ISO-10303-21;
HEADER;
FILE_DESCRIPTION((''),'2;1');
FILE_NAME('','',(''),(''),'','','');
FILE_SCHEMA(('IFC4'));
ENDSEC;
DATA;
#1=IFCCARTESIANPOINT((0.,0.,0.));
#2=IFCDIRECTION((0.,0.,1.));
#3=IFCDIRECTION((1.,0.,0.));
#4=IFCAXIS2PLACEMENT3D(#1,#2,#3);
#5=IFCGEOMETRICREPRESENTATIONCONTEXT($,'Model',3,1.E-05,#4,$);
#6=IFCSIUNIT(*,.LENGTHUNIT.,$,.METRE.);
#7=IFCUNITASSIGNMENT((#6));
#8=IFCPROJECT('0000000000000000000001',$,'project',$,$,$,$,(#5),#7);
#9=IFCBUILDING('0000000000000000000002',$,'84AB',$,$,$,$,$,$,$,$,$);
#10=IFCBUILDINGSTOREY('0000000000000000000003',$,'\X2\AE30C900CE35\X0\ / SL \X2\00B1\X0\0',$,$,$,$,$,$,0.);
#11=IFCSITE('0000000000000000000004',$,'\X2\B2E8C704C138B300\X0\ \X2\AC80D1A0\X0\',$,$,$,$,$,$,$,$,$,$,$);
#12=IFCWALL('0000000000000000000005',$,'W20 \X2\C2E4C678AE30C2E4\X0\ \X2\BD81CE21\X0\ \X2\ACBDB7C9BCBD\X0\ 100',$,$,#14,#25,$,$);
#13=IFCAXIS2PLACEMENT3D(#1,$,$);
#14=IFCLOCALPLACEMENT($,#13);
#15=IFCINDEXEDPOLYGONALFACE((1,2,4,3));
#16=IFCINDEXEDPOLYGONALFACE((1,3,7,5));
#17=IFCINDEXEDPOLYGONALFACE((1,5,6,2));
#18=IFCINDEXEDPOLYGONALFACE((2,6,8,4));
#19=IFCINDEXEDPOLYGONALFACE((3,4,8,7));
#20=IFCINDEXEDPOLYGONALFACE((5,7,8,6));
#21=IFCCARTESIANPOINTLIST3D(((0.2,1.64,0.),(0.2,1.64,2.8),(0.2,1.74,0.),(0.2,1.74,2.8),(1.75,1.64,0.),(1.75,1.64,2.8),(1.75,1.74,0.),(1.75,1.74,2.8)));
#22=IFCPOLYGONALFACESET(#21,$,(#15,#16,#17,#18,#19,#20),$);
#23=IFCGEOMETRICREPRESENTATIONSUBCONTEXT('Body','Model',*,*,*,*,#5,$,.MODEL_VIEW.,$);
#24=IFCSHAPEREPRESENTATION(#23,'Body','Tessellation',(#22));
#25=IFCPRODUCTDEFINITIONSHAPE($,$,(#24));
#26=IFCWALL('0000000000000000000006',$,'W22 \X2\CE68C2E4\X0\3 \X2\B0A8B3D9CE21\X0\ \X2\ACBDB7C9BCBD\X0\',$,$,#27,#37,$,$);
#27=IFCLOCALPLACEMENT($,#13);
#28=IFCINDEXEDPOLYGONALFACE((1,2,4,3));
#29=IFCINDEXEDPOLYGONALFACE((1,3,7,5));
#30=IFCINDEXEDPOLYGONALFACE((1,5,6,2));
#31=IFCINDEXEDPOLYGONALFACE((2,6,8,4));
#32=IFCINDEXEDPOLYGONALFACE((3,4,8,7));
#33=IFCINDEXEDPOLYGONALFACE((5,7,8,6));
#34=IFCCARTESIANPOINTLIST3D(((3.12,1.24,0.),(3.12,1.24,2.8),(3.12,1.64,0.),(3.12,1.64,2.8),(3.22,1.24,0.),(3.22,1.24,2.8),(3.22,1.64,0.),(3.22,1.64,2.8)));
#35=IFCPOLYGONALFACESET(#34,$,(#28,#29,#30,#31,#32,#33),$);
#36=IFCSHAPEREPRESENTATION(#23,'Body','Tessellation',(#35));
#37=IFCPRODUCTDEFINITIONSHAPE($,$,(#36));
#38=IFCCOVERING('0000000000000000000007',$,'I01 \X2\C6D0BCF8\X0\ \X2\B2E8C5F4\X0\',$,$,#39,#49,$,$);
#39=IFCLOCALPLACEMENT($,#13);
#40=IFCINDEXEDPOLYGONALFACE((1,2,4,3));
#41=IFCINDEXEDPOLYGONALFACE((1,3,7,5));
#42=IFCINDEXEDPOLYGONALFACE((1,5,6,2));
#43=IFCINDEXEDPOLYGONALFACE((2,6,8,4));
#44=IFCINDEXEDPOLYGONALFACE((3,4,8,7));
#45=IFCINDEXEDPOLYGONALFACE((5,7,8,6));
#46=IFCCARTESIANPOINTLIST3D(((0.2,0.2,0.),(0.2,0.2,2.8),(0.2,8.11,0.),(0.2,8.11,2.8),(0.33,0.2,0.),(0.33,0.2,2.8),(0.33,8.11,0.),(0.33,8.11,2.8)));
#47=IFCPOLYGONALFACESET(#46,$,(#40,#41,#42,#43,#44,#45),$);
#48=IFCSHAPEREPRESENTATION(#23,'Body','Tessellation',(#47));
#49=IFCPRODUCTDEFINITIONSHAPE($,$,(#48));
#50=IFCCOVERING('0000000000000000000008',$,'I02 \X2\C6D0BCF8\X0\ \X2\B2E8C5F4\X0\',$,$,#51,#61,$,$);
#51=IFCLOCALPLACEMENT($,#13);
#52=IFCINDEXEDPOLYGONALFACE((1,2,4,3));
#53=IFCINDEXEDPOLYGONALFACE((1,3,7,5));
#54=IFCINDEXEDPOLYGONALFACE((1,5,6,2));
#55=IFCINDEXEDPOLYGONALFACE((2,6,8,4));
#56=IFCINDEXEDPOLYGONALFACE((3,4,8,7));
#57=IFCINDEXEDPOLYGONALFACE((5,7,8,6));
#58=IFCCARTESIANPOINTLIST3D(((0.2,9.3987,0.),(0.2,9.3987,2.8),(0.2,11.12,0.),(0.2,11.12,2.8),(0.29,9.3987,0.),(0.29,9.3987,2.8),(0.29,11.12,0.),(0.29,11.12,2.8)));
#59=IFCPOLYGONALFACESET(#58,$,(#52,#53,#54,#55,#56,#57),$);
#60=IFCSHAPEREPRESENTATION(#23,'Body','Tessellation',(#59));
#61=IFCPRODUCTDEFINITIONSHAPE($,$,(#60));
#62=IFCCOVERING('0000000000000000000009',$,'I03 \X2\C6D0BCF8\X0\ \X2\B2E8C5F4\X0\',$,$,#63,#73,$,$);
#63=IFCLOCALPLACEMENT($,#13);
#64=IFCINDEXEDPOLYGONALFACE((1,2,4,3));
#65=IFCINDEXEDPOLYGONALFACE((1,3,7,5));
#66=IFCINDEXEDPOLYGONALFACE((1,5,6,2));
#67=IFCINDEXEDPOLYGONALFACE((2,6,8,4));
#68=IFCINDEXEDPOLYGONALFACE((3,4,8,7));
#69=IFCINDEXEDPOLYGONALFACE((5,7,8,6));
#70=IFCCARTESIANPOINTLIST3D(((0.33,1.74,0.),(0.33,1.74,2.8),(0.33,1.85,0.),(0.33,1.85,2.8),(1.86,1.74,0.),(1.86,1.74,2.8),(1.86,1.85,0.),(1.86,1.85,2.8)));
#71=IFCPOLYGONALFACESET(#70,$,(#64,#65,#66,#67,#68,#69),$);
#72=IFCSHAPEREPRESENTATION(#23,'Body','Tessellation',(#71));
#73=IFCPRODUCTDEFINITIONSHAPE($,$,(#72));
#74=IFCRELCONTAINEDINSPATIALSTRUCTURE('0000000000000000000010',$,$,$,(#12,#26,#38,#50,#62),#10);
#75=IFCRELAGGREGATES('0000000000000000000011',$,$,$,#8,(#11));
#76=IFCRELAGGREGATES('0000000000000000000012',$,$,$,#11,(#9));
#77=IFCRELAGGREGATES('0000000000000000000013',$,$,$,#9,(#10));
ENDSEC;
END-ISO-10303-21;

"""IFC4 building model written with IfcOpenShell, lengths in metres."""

from ifc_helpers import new_model, si_unit, origin, origin_with_axes, place, context, subcontext, project, spatial, polyline, outline, extrude, element, save


model = new_model("IFC4")

# Units and contexts
model_context = context("Model", 3, precision=1e-05, world=origin_with_axes())
body_context = subcontext(model_context, "Body", "Model", "MODEL_VIEW")
ifc_project = project(units=[si_unit("LENGTHUNIT", "METRE")], contexts=[model_context])

# Site, building, storey
site = spatial("IfcSite", under=ifc_project, Name="단위세대 검토")
building = spatial("IfcBuilding", under=site, Name="84AB")
storey = spatial("IfcBuildingStorey", under=building, Name="기준층 / SL ±0", Elevation=0.0)

# Wall
wall_1_placement = place(None, origin_with_axes())
element("IfcWall", 1, at=wall_1_placement, inside=storey, Name="W20 실외기실 북측 경량벽 100", context=body_context, shape_type="SweptSolid", body=[
    extrude(outline(polyline([(1.75, 1.64), (1.75, 1.74), (0.2, 1.74), (0.2, 1.64), (1.75, 1.64)])), origin(), (0.0, 0.0, 1.0), 2.8),
])

# Wall
wall_2_placement = place(None, origin_with_axes())
element("IfcWall", 2, at=wall_2_placement, inside=storey, Name="W22 침실3 남동측 경량벽", context=body_context, shape_type="SweptSolid", body=[
    extrude(outline(polyline([(3.22, 1.24), (3.22, 1.64), (3.12, 1.64), (3.12, 1.24), (3.22, 1.24)])), origin(), (0.0, 0.0, 1.0), 2.8),
])

# Coverings
covering_1_placement = place(None, origin_with_axes())
element("IfcCovering", 3, at=covering_1_placement, inside=storey, Name="I01 원본 단열", context=body_context, shape_type="SweptSolid", body=[
    extrude(outline(polyline([(0.33, 0.2), (0.33, 8.11), (0.2, 8.11), (0.2, 0.2), (0.33, 0.2)])), origin(), (0.0, 0.0, 1.0), 2.8),
])
covering_2_placement = place(None, origin_with_axes())
element("IfcCovering", 4, at=covering_2_placement, inside=storey, Name="I02 원본 단열", context=body_context, shape_type="SweptSolid", body=[
    extrude(outline(polyline([(0.29, 9.3987), (0.29, 11.12), (0.2, 11.12), (0.2, 9.3987), (0.29, 9.3987)])), origin(), (0.0, 0.0, 1.0), 2.8),
])
covering_3_placement = place(None, origin_with_axes())
element("IfcCovering", 5, at=covering_3_placement, inside=storey, Name="I03 원본 단열", context=body_context, shape_type="SweptSolid", body=[
    extrude(outline(polyline([(1.86, 1.74), (1.86, 1.85), (0.33, 1.85), (0.33, 1.74), (1.86, 1.74)])), origin(), (0.0, 0.0, 1.0), 2.8),
])

save(model, "model.ifc")
